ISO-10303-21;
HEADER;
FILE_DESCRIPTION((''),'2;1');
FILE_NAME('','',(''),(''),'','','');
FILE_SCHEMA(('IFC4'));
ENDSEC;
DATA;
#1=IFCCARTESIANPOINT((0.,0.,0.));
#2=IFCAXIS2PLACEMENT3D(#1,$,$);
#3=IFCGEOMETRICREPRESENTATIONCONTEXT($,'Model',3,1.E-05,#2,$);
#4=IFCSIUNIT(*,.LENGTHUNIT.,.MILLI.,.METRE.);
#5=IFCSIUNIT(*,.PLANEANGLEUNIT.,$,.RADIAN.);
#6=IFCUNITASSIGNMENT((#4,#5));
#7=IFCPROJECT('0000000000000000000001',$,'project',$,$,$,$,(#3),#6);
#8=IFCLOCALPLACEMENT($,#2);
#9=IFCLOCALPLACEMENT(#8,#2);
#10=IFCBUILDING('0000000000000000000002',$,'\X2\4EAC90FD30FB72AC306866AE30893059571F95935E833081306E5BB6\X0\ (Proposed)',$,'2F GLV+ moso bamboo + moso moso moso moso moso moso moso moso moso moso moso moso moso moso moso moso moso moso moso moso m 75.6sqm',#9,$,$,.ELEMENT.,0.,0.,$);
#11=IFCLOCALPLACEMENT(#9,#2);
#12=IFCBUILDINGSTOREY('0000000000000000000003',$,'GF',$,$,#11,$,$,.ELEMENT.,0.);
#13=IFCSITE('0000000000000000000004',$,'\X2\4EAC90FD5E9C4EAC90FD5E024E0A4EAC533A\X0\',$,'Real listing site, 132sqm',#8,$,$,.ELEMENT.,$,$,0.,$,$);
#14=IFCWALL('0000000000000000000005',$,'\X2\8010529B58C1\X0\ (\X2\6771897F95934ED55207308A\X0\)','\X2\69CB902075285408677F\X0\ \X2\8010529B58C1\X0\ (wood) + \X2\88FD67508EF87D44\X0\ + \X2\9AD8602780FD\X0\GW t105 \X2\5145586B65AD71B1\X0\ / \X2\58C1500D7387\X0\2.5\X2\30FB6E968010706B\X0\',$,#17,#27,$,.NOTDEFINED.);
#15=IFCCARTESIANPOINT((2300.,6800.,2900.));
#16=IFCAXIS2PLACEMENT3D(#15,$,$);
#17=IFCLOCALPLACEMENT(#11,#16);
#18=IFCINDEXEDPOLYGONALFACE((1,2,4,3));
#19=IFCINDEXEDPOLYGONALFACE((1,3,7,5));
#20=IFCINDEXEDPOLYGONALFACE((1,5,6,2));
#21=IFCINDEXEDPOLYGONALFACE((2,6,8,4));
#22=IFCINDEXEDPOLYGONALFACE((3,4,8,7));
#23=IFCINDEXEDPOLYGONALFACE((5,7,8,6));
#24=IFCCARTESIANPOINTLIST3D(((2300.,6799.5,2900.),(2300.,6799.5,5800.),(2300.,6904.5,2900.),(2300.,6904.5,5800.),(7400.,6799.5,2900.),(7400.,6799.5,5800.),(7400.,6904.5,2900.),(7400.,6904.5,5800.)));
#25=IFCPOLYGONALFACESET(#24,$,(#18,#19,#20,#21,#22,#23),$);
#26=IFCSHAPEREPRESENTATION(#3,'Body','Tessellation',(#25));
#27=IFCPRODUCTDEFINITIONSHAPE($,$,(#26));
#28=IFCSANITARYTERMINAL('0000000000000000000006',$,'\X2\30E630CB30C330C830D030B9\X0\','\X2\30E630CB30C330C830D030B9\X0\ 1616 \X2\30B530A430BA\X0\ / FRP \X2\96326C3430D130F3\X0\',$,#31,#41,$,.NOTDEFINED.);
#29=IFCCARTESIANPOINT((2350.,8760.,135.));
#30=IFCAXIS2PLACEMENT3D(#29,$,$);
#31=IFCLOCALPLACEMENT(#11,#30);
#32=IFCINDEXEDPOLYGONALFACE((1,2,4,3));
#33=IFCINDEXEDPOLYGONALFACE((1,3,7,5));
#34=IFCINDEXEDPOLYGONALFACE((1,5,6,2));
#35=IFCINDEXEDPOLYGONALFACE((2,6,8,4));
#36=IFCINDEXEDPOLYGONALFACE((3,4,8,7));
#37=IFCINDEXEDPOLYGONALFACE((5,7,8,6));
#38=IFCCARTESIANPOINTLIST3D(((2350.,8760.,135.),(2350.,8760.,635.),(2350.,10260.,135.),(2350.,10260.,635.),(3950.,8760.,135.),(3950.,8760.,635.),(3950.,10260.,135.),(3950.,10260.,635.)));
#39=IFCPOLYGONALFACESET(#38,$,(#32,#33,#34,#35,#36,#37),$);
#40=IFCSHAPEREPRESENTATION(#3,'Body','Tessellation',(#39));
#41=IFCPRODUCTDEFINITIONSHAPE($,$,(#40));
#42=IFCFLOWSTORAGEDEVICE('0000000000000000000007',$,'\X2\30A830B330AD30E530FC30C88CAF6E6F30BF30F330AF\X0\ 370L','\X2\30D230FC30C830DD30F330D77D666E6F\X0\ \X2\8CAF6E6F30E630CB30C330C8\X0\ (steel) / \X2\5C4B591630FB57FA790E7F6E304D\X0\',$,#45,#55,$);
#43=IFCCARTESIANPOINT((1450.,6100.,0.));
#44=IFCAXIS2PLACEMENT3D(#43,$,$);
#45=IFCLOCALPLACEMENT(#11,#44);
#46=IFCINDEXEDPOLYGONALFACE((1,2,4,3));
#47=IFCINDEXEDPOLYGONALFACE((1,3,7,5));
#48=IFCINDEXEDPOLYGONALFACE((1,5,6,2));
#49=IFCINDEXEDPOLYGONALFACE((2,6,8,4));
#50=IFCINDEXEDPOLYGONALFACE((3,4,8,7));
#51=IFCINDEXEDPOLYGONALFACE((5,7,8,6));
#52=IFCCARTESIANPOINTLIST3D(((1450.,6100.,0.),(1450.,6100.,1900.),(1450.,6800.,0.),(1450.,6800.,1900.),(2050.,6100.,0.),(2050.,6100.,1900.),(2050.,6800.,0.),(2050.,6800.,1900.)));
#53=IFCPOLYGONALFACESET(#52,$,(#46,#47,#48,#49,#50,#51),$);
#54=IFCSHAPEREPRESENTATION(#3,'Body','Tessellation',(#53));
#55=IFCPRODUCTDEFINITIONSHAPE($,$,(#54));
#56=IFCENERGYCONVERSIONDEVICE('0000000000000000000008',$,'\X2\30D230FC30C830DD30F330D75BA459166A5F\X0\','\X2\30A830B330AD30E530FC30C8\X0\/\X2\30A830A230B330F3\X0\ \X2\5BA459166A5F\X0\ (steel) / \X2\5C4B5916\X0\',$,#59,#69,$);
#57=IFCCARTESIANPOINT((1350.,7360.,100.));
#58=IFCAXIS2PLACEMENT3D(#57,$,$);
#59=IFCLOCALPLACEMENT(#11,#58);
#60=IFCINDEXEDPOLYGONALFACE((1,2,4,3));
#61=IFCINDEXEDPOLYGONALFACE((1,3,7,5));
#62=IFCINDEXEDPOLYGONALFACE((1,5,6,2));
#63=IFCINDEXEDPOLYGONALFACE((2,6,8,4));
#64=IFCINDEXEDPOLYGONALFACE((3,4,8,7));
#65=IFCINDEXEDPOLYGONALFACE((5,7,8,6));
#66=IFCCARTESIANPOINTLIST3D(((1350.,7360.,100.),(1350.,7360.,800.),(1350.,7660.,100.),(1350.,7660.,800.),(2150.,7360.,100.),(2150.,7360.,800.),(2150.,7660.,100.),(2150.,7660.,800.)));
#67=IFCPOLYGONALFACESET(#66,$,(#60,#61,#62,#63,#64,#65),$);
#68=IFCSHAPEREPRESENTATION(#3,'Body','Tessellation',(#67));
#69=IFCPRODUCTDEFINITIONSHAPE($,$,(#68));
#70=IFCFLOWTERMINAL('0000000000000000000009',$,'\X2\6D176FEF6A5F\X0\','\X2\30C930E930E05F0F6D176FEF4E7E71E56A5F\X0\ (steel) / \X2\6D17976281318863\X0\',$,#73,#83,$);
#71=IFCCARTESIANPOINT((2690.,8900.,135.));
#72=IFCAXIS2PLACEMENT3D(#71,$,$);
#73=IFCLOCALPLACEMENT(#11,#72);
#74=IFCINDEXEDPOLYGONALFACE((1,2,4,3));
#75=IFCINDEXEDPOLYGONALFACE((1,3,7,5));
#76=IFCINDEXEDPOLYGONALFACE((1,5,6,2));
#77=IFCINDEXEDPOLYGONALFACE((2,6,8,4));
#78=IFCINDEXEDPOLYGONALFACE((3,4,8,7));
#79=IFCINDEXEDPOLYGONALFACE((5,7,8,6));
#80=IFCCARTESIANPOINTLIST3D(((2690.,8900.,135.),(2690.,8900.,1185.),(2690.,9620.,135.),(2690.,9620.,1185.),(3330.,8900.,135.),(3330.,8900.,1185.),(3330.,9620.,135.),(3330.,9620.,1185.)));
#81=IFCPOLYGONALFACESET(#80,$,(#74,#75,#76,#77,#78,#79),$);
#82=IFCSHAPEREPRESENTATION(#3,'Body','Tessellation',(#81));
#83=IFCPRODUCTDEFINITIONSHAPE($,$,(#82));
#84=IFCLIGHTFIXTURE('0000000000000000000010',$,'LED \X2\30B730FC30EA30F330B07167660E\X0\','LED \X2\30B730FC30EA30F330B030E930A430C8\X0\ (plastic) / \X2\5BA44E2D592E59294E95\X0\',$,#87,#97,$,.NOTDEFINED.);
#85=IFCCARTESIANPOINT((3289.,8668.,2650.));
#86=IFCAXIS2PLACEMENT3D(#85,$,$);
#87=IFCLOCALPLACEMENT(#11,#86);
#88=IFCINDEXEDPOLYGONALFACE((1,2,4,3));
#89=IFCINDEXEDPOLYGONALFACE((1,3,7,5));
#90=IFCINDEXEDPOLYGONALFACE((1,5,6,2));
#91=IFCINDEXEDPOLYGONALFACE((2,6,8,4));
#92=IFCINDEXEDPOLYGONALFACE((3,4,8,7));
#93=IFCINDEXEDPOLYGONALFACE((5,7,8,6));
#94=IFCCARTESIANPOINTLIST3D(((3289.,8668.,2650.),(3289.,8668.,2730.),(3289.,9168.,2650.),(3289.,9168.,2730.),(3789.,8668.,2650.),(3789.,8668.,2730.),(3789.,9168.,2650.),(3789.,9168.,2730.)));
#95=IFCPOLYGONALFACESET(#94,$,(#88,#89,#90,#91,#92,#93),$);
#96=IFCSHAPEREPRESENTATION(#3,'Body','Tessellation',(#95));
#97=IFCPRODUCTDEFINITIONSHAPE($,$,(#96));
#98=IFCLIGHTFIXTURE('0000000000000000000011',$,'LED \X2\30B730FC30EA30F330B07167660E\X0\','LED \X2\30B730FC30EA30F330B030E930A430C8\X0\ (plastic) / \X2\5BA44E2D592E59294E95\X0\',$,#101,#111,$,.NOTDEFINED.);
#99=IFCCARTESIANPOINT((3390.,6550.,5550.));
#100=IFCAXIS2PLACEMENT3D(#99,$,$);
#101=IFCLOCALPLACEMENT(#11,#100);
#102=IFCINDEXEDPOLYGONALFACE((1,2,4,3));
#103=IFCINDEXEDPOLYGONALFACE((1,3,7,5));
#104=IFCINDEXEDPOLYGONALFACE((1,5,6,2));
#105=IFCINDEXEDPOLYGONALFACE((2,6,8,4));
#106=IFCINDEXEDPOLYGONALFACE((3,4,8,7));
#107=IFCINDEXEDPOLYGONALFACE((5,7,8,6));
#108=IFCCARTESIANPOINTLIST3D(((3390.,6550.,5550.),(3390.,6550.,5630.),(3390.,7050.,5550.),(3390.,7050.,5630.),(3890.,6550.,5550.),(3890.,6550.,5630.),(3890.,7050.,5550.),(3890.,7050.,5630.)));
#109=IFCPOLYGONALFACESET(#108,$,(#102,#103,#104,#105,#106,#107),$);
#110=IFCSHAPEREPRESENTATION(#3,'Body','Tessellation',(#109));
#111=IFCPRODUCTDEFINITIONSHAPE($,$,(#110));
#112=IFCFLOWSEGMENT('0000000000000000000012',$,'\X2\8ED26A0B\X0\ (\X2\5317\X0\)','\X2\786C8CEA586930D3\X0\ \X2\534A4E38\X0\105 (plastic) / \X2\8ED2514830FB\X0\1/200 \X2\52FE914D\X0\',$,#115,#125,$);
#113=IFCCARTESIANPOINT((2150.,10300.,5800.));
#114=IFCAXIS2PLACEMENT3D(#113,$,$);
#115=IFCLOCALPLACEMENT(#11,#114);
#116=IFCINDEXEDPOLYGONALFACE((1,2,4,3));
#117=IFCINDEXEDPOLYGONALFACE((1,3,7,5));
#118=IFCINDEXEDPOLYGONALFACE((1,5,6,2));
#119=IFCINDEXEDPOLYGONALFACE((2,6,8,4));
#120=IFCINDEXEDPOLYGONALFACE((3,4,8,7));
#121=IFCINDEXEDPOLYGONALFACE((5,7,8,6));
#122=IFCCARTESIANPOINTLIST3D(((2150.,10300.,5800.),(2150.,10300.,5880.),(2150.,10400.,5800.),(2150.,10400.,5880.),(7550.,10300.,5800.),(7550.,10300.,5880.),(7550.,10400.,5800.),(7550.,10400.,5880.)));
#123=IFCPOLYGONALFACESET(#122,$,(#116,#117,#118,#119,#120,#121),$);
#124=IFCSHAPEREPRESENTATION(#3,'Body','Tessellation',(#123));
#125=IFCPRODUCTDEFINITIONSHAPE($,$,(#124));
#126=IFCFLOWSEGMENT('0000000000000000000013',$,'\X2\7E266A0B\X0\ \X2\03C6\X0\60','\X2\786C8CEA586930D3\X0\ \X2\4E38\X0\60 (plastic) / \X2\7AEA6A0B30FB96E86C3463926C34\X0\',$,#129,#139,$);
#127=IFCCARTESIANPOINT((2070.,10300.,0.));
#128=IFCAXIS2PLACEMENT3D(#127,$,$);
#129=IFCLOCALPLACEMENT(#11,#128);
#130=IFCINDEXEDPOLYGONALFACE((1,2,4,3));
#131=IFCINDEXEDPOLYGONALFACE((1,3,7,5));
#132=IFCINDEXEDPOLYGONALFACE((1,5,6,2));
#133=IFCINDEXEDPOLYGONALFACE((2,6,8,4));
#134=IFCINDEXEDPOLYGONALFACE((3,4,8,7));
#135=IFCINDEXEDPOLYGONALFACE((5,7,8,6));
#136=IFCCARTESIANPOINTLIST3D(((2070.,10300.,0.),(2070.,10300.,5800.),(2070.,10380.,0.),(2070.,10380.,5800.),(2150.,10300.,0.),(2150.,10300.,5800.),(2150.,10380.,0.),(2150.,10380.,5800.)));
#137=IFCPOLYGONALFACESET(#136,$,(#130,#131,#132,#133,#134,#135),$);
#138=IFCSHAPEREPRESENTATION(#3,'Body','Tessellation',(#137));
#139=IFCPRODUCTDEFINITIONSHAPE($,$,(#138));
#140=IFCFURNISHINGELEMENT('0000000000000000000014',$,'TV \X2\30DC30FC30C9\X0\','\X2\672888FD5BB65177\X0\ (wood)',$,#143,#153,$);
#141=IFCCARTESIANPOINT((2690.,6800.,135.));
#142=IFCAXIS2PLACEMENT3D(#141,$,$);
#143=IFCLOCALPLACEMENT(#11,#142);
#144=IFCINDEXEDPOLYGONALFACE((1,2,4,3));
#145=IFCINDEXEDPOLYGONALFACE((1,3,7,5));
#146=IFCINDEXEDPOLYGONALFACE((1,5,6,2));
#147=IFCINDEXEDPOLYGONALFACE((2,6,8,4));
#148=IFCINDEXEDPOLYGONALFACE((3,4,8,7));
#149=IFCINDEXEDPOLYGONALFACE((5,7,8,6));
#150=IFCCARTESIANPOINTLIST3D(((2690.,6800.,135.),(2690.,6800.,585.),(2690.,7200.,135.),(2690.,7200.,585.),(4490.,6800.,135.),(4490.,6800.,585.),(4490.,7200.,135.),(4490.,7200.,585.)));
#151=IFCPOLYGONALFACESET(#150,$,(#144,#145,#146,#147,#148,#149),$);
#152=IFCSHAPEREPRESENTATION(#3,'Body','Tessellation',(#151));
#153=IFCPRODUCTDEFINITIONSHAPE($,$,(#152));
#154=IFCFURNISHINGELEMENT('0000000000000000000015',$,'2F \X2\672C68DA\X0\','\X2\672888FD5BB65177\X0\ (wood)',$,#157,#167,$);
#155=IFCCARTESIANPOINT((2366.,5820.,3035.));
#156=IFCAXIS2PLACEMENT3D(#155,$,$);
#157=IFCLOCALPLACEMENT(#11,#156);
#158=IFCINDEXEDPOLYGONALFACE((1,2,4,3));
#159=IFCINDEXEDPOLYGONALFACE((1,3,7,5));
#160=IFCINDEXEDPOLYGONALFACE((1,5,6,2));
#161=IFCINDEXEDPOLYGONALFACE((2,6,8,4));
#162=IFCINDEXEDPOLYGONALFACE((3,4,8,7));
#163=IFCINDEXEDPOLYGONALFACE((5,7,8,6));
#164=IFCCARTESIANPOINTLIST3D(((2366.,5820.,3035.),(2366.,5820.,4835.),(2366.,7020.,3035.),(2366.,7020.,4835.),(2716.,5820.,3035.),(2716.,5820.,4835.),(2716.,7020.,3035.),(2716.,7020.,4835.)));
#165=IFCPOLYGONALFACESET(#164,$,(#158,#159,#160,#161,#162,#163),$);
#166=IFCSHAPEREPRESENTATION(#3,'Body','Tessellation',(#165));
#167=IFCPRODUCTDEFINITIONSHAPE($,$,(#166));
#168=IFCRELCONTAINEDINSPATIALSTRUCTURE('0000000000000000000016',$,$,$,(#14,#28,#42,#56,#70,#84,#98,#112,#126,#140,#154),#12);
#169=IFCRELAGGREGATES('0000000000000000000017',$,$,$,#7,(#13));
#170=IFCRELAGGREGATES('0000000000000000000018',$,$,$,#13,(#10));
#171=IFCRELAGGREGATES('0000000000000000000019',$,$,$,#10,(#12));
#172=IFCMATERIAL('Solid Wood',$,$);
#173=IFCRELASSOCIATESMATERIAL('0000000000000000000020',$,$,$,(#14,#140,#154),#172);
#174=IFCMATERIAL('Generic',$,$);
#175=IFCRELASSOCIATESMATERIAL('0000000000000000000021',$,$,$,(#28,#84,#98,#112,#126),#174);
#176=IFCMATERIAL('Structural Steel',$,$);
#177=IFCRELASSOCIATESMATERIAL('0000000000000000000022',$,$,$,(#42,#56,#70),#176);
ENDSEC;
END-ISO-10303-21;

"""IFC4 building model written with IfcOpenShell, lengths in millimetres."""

from ifc_helpers import new_model, si_unit, frame, frame_2d, origin, place, context, project, spatial, rectangle, extrude, material, element, save


model = new_model("IFC4")

# Units and contexts
model_context = context("Model", 3, precision=1e-05, world=origin())
ifc_project = project(units=[si_unit("LENGTHUNIT", "METRE", prefix="MILLI"), si_unit("PLANEANGLEUNIT", "RADIAN")], contexts=[model_context])

# Site, building, storey
site_placement = place(None, origin())
site = spatial("IfcSite", under=ifc_project, at=site_placement, Name="京都府京都市上京区", ObjectType="Real listing site, 132sqm", CompositionType="ELEMENT", RefElevation=0.0)
building_placement = place(site_placement, origin())
building = spatial("IfcBuilding", under=site, at=building_placement, Name="京都・犬と暮らす土間広めの家 (Proposed)", ObjectType="2F GLV+ moso bamboo + moso moso moso moso moso moso moso moso moso moso moso moso moso moso moso moso moso moso moso moso m 75.6sqm", CompositionType="ELEMENT", ElevationOfRefHeight=0.0, ElevationOfTerrain=0.0)
storey_placement = place(building_placement, origin())
storey = spatial("IfcBuildingStorey", under=building, at=storey_placement, Name="GF", CompositionType="ELEMENT", Elevation=0.0)

# Shared definitions
ifc_material_1 = material(Name="Solid Wood")

# Wall
wall_1_placement = place(storey_placement, frame((2300.0, 6800.0, 2900.0)))
element("IfcWall", 1, at=wall_1_placement, inside=storey, material=ifc_material_1, Name="耐力壁 (東西間仕切り)", Description="構造用合板 耐力壁 (wood) + 製材軸組 + 高性能GW t105 充填断熱 / 壁倍率2.5・準耐火", PredefinedType="NOTDEFINED", context=model_context, shape_type="SweptSolid", body=[
    extrude(rectangle(XDim=5100.0, YDim=105.0, at=frame_2d((2550.0, 52.0))), frame((2300.0, 6800.0, 2900.0)), (0.0, 0.0, 1.0), 2900.0),
])

# Sanitary terminal
ifc_material_2 = material(Name="Generic")
sanitary_terminal_placement = place(storey_placement, frame((2350.0, 8760.0, 135.0)))
element("IfcSanitaryTerminal", 2, at=sanitary_terminal_placement, inside=storey, material=ifc_material_2, Name="ユニットバス", Description="ユニットバス 1616 サイズ / FRP 防水パン", PredefinedType="NOTDEFINED", context=model_context, shape_type="SweptSolid", body=[
    extrude(rectangle(XDim=1600.0, YDim=1500.0, at=frame_2d((800.0, 750.0))), frame((2350.0, 8760.0, 135.0)), (0.0, 0.0, 1.0), 500.0),
])

# Flow storage device
ifc_material_3 = material(Name="Structural Steel")
flow_storage_device_placement = place(storey_placement, frame((1450.0, 6100.0, 0.0)))
element("IfcFlowStorageDevice", 3, at=flow_storage_device_placement, inside=storey, material=ifc_material_3, Name="エコキュート貯湯タンク 370L", Description="ヒートポンプ給湯 貯湯ユニット (steel) / 屋外・基礎置き", context=model_context, shape_type="SweptSolid", body=[
    extrude(rectangle(XDim=600.0, YDim=700.0, at=frame_2d((300.0, 350.0))), frame((1450.0, 6100.0, 0.0)), (0.0, 0.0, 1.0), 1900.0),
])

# Energy conversion device
energy_conversion_device_placement = place(storey_placement, frame((1350.0, 7360.0, 100.0)))
element("IfcEnergyConversionDevice", 4, at=energy_conversion_device_placement, inside=storey, material=ifc_material_3, Name="ヒートポンプ室外機", Description="エコキュート/エアコン 室外機 (steel) / 屋外", context=model_context, shape_type="SweptSolid", body=[
    extrude(rectangle(XDim=800.0, YDim=300.0, at=frame_2d((400.0, 150.0))), frame((1350.0, 7360.0, 100.0)), (0.0, 0.0, 1.0), 700.0),
])

# Flow terminal
flow_terminal_placement = place(storey_placement, frame((2690.0, 8900.0, 135.0)))
element("IfcFlowTerminal", 5, at=flow_terminal_placement, inside=storey, material=ifc_material_3, Name="洗濯機", Description="ドラム式洗濯乾燥機 (steel) / 洗面脱衣", context=model_context, shape_type="SweptSolid", body=[
    extrude(rectangle(XDim=640.0, YDim=720.0, at=frame_2d((320.0, 360.0))), frame((2690.0, 8900.0, 135.0)), (0.0, 0.0, 1.0), 1050.0),
])

# Light fixtures
light_fixture_1_placement = place(storey_placement, frame((3289.0, 8668.0, 2650.0)))
element("IfcLightFixture", 6, at=light_fixture_1_placement, inside=storey, material=ifc_material_2, Name="LED シーリング照明", Description="LED シーリングライト (plastic) / 室中央天井", PredefinedType="NOTDEFINED", context=model_context, shape_type="SweptSolid", body=[
    extrude(rectangle(XDim=500.0, YDim=500.0, at=frame_2d((250.0, 250.0))), frame((3289.0, 8668.0, 2650.0)), (0.0, 0.0, 1.0), 80.0),
])
light_fixture_2_placement = place(storey_placement, frame((3390.0, 6550.0, 5550.0)))
element("IfcLightFixture", 7, at=light_fixture_2_placement, inside=storey, material=ifc_material_2, Name="LED シーリング照明", Description="LED シーリングライト (plastic) / 室中央天井", PredefinedType="NOTDEFINED", context=model_context, shape_type="SweptSolid", body=[
    extrude(rectangle(XDim=500.0, YDim=500.0, at=frame_2d((250.0, 250.0))), frame((3390.0, 6550.0, 5550.0)), (0.0, 0.0, 1.0), 80.0),
])

# Flow segments
flow_segment_1_placement = place(storey_placement, frame((2150.0, 10300.0, 5800.0)))
element("IfcFlowSegment", 8, at=flow_segment_1_placement, inside=storey, material=ifc_material_2, Name="軒樋 (北)", Description="硬質塩ビ 半丸105 (plastic) / 軒先・1/200 勾配", context=model_context, shape_type="SweptSolid", body=[
    extrude(rectangle(XDim=5400.0, YDim=100.0, at=frame_2d((2700.0, 50.0))), frame((2150.0, 10300.0, 5800.0)), (0.0, 0.0, 1.0), 80.0),
])
flow_segment_2_placement = place(storey_placement, frame((2070.0, 10300.0, 0.0)))
element("IfcFlowSegment", 9, at=flow_segment_2_placement, inside=storey, material=ifc_material_2, Name="縦樋 φ60", Description="硬質塩ビ 丸60 (plastic) / 竪樋・雨水排水", context=model_context, shape_type="SweptSolid", body=[
    extrude(rectangle(XDim=80.0, YDim=80.0, at=frame_2d((40.0, 40.0))), frame((2070.0, 10300.0, 0.0)), (0.0, 0.0, 1.0), 5800.0),
])

# Furnishing elements
furnishing_1_placement = place(storey_placement, frame((2690.0, 6800.0, 135.0)))
element("IfcFurnishingElement", 10, at=furnishing_1_placement, inside=storey, material=ifc_material_1, Name="TV ボード", Description="木製家具 (wood)", context=model_context, shape_type="SweptSolid", body=[
    extrude(rectangle(XDim=1800.0, YDim=400.0, at=frame_2d((900.0, 200.0))), frame((2690.0, 6800.0, 135.0)), (0.0, 0.0, 1.0), 450.0),
])
furnishing_2_placement = place(storey_placement, frame((2366.0, 5820.0, 3035.0)))
element("IfcFurnishingElement", 11, at=furnishing_2_placement, inside=storey, material=ifc_material_1, Name="2F 本棚", Description="木製家具 (wood)", context=model_context, shape_type="SweptSolid", body=[
    extrude(rectangle(XDim=350.0, YDim=1200.0, at=frame_2d((175.0, 600.0))), frame((2366.0, 5820.0, 3035.0)), (0.0, 0.0, 1.0), 1800.0),
])

save(model, "model.ifc")
